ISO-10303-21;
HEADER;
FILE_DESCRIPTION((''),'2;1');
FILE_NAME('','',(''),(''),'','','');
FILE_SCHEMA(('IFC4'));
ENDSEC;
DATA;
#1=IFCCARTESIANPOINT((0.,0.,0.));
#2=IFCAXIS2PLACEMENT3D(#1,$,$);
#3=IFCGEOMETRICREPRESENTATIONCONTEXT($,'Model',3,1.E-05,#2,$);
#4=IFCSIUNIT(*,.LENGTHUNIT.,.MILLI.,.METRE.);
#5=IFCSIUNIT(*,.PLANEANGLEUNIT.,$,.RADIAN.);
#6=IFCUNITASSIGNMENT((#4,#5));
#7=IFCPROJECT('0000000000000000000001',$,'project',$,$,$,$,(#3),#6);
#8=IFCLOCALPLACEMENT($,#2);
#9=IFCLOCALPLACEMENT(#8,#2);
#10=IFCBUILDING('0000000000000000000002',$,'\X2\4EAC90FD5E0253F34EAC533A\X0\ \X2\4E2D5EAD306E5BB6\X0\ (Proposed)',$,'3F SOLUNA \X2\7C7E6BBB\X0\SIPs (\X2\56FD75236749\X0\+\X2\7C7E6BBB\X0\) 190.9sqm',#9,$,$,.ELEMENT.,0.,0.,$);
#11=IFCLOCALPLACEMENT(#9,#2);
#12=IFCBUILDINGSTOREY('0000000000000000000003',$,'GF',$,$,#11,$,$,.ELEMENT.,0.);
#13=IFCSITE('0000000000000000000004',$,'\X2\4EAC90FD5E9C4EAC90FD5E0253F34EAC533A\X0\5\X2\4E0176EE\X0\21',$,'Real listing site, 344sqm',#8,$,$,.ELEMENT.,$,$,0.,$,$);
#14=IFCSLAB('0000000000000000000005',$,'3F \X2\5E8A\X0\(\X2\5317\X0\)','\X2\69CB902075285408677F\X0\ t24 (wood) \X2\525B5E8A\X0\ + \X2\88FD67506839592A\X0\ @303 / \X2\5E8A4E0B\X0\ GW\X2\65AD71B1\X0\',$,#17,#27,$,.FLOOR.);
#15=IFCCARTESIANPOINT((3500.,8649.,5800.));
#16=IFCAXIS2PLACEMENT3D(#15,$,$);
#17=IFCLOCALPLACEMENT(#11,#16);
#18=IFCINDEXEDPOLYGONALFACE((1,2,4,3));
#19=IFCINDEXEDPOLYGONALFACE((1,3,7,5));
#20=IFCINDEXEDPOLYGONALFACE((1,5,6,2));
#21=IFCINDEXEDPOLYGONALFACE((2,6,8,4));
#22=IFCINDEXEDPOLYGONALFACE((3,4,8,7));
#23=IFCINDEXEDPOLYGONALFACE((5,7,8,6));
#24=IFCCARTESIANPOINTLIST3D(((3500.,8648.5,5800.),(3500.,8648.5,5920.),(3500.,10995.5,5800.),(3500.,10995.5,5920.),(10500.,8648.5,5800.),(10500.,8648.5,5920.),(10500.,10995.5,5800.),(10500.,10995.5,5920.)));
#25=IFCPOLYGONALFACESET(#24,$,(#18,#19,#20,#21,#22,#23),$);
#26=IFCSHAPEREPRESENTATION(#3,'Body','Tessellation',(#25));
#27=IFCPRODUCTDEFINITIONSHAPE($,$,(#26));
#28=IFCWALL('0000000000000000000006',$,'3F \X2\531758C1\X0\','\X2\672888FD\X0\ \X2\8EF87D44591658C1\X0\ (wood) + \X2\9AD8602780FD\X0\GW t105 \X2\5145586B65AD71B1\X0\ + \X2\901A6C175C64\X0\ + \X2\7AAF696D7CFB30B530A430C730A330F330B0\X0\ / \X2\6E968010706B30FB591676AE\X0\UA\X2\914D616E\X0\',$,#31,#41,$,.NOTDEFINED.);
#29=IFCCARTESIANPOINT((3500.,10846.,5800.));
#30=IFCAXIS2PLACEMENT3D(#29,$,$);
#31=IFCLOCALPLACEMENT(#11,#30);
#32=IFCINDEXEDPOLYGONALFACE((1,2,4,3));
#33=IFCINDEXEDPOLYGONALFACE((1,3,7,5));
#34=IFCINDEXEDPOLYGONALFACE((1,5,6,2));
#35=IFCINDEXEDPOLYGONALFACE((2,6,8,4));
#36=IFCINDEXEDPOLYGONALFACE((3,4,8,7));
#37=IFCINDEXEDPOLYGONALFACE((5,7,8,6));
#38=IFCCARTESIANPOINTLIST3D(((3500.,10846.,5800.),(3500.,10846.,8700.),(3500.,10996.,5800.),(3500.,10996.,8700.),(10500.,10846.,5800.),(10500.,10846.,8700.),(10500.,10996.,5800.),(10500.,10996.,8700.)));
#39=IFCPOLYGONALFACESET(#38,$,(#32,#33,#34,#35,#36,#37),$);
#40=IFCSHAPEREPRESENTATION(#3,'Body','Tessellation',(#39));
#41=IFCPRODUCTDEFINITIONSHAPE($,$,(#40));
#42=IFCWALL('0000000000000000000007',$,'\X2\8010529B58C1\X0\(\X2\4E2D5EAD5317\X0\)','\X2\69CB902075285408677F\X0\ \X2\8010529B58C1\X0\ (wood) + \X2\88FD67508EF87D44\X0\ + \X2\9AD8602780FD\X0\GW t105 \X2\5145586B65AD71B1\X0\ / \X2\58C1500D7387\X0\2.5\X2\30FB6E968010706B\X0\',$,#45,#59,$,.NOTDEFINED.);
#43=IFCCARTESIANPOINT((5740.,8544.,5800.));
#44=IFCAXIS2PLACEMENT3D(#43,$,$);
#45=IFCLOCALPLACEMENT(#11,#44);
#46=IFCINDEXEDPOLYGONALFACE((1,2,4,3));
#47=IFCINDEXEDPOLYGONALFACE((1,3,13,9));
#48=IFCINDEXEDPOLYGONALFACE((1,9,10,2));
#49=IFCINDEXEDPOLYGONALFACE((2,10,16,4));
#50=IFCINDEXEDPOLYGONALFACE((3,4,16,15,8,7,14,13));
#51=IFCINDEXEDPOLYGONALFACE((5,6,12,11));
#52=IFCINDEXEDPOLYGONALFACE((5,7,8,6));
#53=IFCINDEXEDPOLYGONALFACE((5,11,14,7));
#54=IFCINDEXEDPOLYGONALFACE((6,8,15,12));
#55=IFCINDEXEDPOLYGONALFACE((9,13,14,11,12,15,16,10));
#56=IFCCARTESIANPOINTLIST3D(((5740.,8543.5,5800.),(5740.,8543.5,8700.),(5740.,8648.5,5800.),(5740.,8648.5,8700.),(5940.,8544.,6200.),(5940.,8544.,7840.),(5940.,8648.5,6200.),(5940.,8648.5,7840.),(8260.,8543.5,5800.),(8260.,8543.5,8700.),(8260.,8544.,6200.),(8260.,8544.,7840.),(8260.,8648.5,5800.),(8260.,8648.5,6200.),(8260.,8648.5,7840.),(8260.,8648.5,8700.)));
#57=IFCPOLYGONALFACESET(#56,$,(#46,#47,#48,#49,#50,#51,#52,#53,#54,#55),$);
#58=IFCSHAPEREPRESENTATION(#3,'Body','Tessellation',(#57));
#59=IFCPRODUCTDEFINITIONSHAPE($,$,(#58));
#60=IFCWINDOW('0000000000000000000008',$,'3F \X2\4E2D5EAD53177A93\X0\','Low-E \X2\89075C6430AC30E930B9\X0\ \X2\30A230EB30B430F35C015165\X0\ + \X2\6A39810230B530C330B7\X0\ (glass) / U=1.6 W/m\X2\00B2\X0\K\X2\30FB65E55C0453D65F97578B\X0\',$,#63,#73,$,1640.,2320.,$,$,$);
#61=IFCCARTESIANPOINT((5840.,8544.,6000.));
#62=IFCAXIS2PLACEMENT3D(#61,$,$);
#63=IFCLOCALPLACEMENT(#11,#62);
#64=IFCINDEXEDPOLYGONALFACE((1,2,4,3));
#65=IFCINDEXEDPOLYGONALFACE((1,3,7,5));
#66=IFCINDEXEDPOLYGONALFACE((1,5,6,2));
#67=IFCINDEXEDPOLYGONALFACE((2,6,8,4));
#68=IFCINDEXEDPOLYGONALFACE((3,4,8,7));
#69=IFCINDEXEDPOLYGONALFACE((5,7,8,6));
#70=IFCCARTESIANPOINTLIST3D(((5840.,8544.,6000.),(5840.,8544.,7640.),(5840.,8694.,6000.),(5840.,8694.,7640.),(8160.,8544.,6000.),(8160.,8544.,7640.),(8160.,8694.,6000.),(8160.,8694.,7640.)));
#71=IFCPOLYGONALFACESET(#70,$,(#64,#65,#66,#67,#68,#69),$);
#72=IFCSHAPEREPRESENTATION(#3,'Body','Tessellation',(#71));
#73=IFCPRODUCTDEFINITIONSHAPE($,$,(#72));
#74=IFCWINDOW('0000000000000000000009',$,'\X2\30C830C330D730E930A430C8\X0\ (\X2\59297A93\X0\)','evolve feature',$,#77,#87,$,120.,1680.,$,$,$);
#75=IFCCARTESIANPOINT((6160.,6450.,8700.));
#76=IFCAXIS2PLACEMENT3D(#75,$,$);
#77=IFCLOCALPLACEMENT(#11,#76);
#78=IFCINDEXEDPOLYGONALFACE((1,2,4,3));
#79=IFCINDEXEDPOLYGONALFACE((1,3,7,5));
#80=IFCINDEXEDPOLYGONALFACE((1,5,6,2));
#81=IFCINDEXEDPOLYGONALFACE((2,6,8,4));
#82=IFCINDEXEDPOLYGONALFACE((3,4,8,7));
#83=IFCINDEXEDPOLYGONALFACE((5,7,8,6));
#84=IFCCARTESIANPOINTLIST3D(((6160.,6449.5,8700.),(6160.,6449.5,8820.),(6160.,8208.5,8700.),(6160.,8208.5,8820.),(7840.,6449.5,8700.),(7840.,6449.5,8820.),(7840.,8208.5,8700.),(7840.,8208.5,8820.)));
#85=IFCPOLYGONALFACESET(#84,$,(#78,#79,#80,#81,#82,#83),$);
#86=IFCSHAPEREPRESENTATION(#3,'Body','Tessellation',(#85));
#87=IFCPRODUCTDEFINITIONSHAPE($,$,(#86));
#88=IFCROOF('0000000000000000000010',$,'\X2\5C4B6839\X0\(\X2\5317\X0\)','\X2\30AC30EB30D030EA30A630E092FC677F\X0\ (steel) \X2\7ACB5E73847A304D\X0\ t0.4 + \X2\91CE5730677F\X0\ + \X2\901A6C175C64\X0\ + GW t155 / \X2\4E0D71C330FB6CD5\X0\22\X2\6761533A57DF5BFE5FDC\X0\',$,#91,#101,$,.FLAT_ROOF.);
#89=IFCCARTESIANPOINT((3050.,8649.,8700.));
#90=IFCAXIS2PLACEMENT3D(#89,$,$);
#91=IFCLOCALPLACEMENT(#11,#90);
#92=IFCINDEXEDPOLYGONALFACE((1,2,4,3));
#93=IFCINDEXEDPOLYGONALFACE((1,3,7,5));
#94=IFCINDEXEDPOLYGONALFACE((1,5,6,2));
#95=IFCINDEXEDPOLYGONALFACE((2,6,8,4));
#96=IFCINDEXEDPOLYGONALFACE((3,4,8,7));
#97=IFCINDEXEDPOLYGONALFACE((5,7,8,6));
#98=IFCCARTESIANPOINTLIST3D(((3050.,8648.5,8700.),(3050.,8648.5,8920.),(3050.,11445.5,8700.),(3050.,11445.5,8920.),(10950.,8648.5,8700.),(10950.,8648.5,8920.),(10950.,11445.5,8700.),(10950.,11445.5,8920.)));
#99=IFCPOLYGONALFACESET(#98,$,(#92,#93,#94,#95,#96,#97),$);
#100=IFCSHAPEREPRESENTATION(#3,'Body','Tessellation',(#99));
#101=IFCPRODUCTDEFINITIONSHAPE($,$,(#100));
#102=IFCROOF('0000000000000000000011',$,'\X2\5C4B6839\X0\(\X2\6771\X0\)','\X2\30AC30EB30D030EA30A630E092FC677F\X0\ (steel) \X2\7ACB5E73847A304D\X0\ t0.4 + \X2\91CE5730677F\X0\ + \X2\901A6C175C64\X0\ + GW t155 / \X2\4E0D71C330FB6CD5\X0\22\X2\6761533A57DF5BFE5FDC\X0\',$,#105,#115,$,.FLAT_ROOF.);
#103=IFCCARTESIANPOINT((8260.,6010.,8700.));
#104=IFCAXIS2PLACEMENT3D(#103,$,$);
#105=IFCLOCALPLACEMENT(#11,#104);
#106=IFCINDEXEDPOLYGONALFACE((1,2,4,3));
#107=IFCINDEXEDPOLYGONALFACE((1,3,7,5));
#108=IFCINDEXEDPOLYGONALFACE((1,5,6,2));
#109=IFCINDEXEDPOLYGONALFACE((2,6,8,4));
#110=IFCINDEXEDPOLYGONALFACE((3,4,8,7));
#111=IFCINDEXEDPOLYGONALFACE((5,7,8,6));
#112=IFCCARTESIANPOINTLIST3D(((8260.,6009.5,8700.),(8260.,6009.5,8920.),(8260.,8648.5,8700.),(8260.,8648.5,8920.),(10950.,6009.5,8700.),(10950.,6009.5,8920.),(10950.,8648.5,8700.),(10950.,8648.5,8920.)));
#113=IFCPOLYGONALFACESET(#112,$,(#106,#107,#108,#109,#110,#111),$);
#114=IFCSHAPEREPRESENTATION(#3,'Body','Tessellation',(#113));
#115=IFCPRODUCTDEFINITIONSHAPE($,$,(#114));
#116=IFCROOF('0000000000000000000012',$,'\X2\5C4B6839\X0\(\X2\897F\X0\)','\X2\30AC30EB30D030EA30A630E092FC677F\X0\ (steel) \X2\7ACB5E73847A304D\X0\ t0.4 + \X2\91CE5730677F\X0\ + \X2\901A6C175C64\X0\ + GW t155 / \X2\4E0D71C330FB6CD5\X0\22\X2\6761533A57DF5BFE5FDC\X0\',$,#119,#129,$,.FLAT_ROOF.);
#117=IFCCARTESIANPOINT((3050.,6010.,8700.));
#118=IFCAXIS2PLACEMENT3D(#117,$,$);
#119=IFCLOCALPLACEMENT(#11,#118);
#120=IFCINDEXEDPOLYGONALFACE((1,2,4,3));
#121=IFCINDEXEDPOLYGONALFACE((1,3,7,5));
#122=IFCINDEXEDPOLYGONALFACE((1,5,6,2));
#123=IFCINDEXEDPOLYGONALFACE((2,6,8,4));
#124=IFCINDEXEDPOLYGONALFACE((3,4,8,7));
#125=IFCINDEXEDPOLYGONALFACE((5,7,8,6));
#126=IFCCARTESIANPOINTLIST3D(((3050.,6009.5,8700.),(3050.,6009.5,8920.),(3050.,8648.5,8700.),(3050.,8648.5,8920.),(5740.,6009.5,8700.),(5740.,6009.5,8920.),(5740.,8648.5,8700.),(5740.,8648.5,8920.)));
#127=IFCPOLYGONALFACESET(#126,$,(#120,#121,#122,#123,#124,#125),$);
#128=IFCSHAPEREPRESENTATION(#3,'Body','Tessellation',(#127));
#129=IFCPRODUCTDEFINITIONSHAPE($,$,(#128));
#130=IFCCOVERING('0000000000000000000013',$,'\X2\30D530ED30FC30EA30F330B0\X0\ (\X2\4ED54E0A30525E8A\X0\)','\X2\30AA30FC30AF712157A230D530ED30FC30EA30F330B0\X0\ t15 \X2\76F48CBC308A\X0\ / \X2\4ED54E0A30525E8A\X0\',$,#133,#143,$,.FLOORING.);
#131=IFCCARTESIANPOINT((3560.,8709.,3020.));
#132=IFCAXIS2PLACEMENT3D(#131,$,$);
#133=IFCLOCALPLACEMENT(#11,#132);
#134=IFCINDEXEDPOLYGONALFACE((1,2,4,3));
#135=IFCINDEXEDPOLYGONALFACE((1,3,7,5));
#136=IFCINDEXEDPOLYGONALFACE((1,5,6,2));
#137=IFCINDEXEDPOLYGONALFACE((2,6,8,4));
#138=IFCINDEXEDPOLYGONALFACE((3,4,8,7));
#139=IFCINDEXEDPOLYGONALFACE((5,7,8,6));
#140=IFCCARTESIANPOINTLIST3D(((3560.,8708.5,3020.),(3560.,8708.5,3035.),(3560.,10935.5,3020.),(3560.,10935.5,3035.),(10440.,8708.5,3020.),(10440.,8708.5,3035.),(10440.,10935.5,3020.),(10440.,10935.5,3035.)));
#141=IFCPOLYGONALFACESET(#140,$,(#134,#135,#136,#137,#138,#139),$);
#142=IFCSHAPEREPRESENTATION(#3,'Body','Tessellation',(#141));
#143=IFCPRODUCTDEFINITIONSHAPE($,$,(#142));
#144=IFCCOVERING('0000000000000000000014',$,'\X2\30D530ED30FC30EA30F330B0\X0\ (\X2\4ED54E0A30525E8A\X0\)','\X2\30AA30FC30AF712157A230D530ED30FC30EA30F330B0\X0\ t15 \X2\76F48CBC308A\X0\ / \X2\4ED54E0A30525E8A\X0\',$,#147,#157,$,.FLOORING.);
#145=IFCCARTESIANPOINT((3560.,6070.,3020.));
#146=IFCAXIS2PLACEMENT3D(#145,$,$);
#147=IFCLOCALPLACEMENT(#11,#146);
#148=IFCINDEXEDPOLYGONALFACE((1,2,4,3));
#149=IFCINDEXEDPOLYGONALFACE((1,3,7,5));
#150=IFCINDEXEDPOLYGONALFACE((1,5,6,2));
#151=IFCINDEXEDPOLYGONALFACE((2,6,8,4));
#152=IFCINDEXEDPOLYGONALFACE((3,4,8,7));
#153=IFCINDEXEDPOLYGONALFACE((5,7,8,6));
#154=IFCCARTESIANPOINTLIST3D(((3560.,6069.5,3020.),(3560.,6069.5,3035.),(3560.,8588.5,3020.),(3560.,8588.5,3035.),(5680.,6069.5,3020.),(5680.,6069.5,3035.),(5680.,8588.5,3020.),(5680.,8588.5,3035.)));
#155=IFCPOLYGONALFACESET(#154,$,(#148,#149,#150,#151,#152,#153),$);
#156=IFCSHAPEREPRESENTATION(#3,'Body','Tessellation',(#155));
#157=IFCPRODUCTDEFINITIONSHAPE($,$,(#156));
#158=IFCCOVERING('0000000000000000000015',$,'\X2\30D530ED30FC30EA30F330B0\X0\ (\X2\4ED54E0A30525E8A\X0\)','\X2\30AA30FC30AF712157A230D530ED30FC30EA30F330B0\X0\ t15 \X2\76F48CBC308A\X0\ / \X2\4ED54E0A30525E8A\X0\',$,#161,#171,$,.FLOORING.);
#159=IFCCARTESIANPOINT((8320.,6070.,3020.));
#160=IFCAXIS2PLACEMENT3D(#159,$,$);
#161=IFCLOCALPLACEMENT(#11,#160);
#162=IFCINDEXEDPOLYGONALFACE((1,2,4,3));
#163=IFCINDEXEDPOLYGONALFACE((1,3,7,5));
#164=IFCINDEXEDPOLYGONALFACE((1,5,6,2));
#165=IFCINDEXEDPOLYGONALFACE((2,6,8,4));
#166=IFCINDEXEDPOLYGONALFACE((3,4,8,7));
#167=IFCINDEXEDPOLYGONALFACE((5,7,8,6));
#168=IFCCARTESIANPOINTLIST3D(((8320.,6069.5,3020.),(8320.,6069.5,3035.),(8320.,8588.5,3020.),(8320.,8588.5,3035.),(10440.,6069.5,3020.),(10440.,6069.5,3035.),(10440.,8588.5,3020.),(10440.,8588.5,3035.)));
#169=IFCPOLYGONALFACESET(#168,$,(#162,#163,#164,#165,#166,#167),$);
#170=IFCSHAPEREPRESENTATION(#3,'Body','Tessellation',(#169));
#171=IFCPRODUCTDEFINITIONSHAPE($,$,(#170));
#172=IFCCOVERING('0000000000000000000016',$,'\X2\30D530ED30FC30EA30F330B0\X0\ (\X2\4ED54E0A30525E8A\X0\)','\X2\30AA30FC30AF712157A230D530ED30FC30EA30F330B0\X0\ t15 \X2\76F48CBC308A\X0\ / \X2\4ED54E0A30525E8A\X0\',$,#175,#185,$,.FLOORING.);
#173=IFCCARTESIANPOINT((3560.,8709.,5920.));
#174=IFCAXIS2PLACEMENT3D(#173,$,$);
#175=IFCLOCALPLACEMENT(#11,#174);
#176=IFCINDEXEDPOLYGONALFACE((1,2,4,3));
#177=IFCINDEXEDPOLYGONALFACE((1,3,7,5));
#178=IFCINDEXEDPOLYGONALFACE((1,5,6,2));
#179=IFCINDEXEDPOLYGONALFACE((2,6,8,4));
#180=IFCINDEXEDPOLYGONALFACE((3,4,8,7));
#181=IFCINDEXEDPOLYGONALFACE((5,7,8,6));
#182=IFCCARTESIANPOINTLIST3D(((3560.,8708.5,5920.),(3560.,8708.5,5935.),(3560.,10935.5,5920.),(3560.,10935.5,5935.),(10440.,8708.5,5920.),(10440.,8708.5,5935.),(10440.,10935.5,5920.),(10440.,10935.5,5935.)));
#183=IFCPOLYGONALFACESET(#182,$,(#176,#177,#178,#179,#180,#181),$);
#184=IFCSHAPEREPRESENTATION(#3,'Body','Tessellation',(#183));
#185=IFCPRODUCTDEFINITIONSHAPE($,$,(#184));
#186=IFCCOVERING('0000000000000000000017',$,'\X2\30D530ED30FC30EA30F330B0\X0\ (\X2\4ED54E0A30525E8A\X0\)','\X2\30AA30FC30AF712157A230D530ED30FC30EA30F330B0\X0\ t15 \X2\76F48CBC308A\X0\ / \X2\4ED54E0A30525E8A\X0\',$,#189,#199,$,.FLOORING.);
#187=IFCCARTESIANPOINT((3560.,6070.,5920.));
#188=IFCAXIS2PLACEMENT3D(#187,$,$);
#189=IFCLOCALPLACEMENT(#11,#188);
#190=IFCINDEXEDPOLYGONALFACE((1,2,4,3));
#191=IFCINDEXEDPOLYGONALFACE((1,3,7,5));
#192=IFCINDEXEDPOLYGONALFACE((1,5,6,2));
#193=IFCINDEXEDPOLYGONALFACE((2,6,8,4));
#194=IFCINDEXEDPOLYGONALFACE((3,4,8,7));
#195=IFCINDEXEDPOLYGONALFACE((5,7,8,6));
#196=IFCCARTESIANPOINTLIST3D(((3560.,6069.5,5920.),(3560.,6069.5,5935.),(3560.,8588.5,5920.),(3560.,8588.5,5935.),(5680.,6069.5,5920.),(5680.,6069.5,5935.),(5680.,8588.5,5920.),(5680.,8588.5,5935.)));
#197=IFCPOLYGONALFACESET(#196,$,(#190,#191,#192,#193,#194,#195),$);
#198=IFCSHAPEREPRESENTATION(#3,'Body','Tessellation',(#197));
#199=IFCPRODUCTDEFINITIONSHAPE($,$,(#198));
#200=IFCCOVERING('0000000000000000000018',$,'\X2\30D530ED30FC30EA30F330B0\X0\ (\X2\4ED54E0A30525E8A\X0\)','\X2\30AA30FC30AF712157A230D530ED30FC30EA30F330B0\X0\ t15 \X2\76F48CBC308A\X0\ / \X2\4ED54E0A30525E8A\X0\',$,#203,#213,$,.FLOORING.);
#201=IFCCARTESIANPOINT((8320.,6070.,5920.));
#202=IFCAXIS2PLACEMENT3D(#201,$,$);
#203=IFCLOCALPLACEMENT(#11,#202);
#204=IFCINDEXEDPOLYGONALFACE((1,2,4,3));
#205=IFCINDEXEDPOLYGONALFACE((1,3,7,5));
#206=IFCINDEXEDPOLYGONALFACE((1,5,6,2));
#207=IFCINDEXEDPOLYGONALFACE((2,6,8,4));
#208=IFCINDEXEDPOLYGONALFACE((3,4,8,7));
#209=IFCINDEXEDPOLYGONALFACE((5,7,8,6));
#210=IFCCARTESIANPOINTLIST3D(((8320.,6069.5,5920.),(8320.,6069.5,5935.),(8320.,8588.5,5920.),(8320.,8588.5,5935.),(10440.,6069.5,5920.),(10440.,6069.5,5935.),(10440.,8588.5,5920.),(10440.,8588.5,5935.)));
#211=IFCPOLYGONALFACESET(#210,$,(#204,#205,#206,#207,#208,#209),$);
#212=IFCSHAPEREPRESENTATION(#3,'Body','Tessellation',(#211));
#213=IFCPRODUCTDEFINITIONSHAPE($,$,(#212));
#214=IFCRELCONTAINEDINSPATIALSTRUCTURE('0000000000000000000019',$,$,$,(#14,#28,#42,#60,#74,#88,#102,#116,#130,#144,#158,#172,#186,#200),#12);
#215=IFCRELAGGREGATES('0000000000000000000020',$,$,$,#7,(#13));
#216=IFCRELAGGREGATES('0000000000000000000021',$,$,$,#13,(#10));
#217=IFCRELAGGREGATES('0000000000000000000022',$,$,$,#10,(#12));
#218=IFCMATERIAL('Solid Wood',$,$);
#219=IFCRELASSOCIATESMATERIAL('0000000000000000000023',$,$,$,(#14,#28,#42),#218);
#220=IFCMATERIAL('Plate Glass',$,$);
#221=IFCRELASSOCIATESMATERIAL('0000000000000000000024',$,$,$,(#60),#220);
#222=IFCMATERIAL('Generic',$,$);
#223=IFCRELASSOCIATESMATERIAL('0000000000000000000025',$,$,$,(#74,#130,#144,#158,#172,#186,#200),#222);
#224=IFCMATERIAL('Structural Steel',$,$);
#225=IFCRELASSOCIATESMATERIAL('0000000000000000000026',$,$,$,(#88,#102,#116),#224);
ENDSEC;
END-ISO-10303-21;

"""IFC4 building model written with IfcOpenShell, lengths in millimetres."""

from ifc_helpers import new_model, si_unit, frame, frame_2d, origin, place, context, project, spatial, rectangle, extrude, material, element, fill, save


model = new_model("IFC4")

# Units and contexts
model_context = context("Model", 3, precision=1e-05, world=origin())
ifc_project = project(units=[si_unit("LENGTHUNIT", "METRE", prefix="MILLI"), si_unit("PLANEANGLEUNIT", "RADIAN")], contexts=[model_context])

# Site, building, storey
site_placement = place(None, origin())
site = spatial("IfcSite", under=ifc_project, at=site_placement, Name="京都府京都市右京区5丁目21", ObjectType="Real listing site, 344sqm", CompositionType="ELEMENT", RefElevation=0.0)
building_placement = place(site_placement, origin())
building = spatial("IfcBuilding", under=site, at=building_placement, Name="京都市右京区 中庭の家 (Proposed)", ObjectType="3F SOLUNA 籾殻SIPs (国産杉+籾殻) 190.9sqm", CompositionType="ELEMENT", ElevationOfRefHeight=0.0, ElevationOfTerrain=0.0)
storey_placement = place(building_placement, origin())
storey = spatial("IfcBuildingStorey", under=building, at=storey_placement, Name="GF", CompositionType="ELEMENT", Elevation=0.0)

# Slab
ifc_material_1 = material(Name="Solid Wood")
slab_placement = place(storey_placement, frame((3500.0, 8649.0, 5800.0)))
element("IfcSlab", 1, at=slab_placement, inside=storey, material=ifc_material_1, Name="3F 床(北)", Description="構造用合板 t24 (wood) 剛床 + 製材根太 @303 / 床下 GW断熱", PredefinedType="FLOOR", context=model_context, shape_type="SweptSolid", body=[
    extrude(rectangle(XDim=7000.0, YDim=2347.0, at=frame_2d((3500.0, 1173.0))), frame((3500.0, 8649.0, 5800.0)), (0.0, 0.0, 1.0), 120.0),
])

# Wall
wall_1_placement = place(storey_placement, frame((3500.0, 10846.0, 5800.0)))
element("IfcWall", 2, at=wall_1_placement, inside=storey, material=ifc_material_1, Name="3F 北壁", Description="木製 軸組外壁 (wood) + 高性能GW t105 充填断熱 + 通気層 + 窯業系サイディング / 準耐火・外皮UA配慮", PredefinedType="NOTDEFINED", context=model_context, shape_type="SweptSolid", body=[
    extrude(rectangle(XDim=7000.0, YDim=150.0, at=frame_2d((3500.0, 75.0))), frame((3500.0, 10846.0, 5800.0)), (0.0, 0.0, 1.0), 2900.0),
])

# Wall, opening, window
wall_2_placement = place(storey_placement, frame((5740.0, 8544.0, 5800.0)))
wall_2 = element("IfcWall", 3, at=wall_2_placement, inside=storey, material=ifc_material_1, Name="耐力壁(中庭北)", Description="構造用合板 耐力壁 (wood) + 製材軸組 + 高性能GW t105 充填断熱 / 壁倍率2.5・準耐火", PredefinedType="NOTDEFINED", context=model_context, shape_type="SweptSolid", body=[
    extrude(rectangle(XDim=2520.0, YDim=105.0, at=frame_2d((1260.0, 52.0))), frame((5740.0, 8544.0, 5800.0)), (0.0, 0.0, 1.0), 2900.0),
])
opening_placement = place(storey_placement, frame((5840.0, 8544.0, 6000.0)))
opening = element("IfcOpeningElement", 4, at=opening_placement, cuts=wall_2, PredefinedType="NOTDEFINED", context=model_context, shape_type="SweptSolid", body=[
    extrude(rectangle(XDim=2320.0, YDim=150.0, at=frame_2d((1160.0, 75.0))), frame((5840.0, 8544.0, 6000.0)), (0.0, 0.0, 1.0), 1640.0),
])
ifc_material_2 = material(Name="Plate Glass")
window_1_placement = place(storey_placement, frame((5840.0, 8544.0, 6000.0)))
window_1 = element("IfcWindow", 5, at=window_1_placement, inside=storey, material=ifc_material_2, Name="3F 中庭北窓", Description="Low-E 複層ガラス アルゴン封入 + 樹脂サッシ (glass) / U=1.6 W/m²K・日射取得型", OverallHeight=1640.0, OverallWidth=2320.0, context=model_context, shape_type="SweptSolid", body=[
    extrude(rectangle(XDim=2320.0, YDim=150.0, at=frame_2d((1160.0, 75.0))), frame((5840.0, 8544.0, 6000.0)), (0.0, 0.0, 1.0), 1640.0),
])
fill(opening, window_1)

# Window
ifc_material_3 = material(Name="Generic")
window_2_placement = place(storey_placement, frame((6160.0, 6450.0, 8700.0)))
element("IfcWindow", 6, at=window_2_placement, inside=storey, material=ifc_material_3, Name="トップライト (天窓)", Description="evolve feature", OverallHeight=120.0, OverallWidth=1680.0, context=model_context, shape_type="SweptSolid", body=[
    extrude(rectangle(XDim=1680.0, YDim=1759.0, at=frame_2d((840.0, 879.0))), frame((6160.0, 6450.0, 8700.0)), (0.0, 0.0, 1.0), 120.0),
])

# Roofs
ifc_material_4 = material(Name="Structural Steel")
roof_1_placement = place(storey_placement, frame((3050.0, 8649.0, 8700.0)))
element("IfcRoof", 7, at=roof_1_placement, inside=storey, material=ifc_material_4, Name="屋根(北)", Description="ガルバリウム鋼板 (steel) 立平葺き t0.4 + 野地板 + 通気層 + GW t155 / 不燃・法22条区域対応", PredefinedType="FLAT_ROOF", context=model_context, shape_type="SweptSolid", body=[
    extrude(rectangle(XDim=7900.0, YDim=2797.0, at=frame_2d((3950.0, 1398.0))), frame((3050.0, 8649.0, 8700.0)), (0.0, 0.0, 1.0), 220.0),
])
roof_2_placement = place(storey_placement, frame((8260.0, 6010.0, 8700.0)))
element("IfcRoof", 8, at=roof_2_placement, inside=storey, material=ifc_material_4, Name="屋根(東)", Description="ガルバリウム鋼板 (steel) 立平葺き t0.4 + 野地板 + 通気層 + GW t155 / 不燃・法22条区域対応", PredefinedType="FLAT_ROOF", context=model_context, shape_type="SweptSolid", body=[
    extrude(rectangle(XDim=2690.0, YDim=2639.0, at=frame_2d((1345.0, 1319.0))), frame((8260.0, 6010.0, 8700.0)), (0.0, 0.0, 1.0), 220.0),
])
roof_3_placement = place(storey_placement, frame((3050.0, 6010.0, 8700.0)))
element("IfcRoof", 9, at=roof_3_placement, inside=storey, material=ifc_material_4, Name="屋根(西)", Description="ガルバリウム鋼板 (steel) 立平葺き t0.4 + 野地板 + 通気層 + GW t155 / 不燃・法22条区域対応", PredefinedType="FLAT_ROOF", context=model_context, shape_type="SweptSolid", body=[
    extrude(rectangle(XDim=2690.0, YDim=2639.0, at=frame_2d((1345.0, 1319.0))), frame((3050.0, 6010.0, 8700.0)), (0.0, 0.0, 1.0), 220.0),
])

# Coverings
covering_1_placement = place(storey_placement, frame((3560.0, 8709.0, 3020.0)))
element("IfcCovering", 10, at=covering_1_placement, inside=storey, material=ifc_material_3, Name="フローリング (仕上げ床)", Description="オーク無垢フローリング t15 直貼り / 仕上げ床", PredefinedType="FLOORING", context=model_context, shape_type="SweptSolid", body=[
    extrude(rectangle(XDim=6880.0, YDim=2227.0, at=frame_2d((3440.0, 1113.0))), frame((3560.0, 8709.0, 3020.0)), (0.0, 0.0, 1.0), 15.0),
])
covering_2_placement = place(storey_placement, frame((3560.0, 6070.0, 3020.0)))
element("IfcCovering", 11, at=covering_2_placement, inside=storey, material=ifc_material_3, Name="フローリング (仕上げ床)", Description="オーク無垢フローリング t15 直貼り / 仕上げ床", PredefinedType="FLOORING", context=model_context, shape_type="SweptSolid", body=[
    extrude(rectangle(XDim=2120.0, YDim=2519.0, at=frame_2d((1060.0, 1259.0))), frame((3560.0, 6070.0, 3020.0)), (0.0, 0.0, 1.0), 15.0),
])
covering_3_placement = place(storey_placement, frame((8320.0, 6070.0, 3020.0)))
element("IfcCovering", 12, at=covering_3_placement, inside=storey, material=ifc_material_3, Name="フローリング (仕上げ床)", Description="オーク無垢フローリング t15 直貼り / 仕上げ床", PredefinedType="FLOORING", context=model_context, shape_type="SweptSolid", body=[
    extrude(rectangle(XDim=2120.0, YDim=2519.0, at=frame_2d((1060.0, 1259.0))), frame((8320.0, 6070.0, 3020.0)), (0.0, 0.0, 1.0), 15.0),
])
covering_4_placement = place(storey_placement, frame((3560.0, 8709.0, 5920.0)))
element("IfcCovering", 13, at=covering_4_placement, inside=storey, material=ifc_material_3, Name="フローリング (仕上げ床)", Description="オーク無垢フローリング t15 直貼り / 仕上げ床", PredefinedType="FLOORING", context=model_context, shape_type="SweptSolid", body=[
    extrude(rectangle(XDim=6880.0, YDim=2227.0, at=frame_2d((3440.0, 1113.0))), frame((3560.0, 8709.0, 5920.0)), (0.0, 0.0, 1.0), 15.0),
])
covering_5_placement = place(storey_placement, frame((3560.0, 6070.0, 5920.0)))
element("IfcCovering", 14, at=covering_5_placement, inside=storey, material=ifc_material_3, Name="フローリング (仕上げ床)", Description="オーク無垢フローリング t15 直貼り / 仕上げ床", PredefinedType="FLOORING", context=model_context, shape_type="SweptSolid", body=[
    extrude(rectangle(XDim=2120.0, YDim=2519.0, at=frame_2d((1060.0, 1259.0))), frame((3560.0, 6070.0, 5920.0)), (0.0, 0.0, 1.0), 15.0),
])
covering_6_placement = place(storey_placement, frame((8320.0, 6070.0, 5920.0)))
element("IfcCovering", 15, at=covering_6_placement, inside=storey, material=ifc_material_3, Name="フローリング (仕上げ床)", Description="オーク無垢フローリング t15 直貼り / 仕上げ床", PredefinedType="FLOORING", context=model_context, shape_type="SweptSolid", body=[
    extrude(rectangle(XDim=2120.0, YDim=2519.0, at=frame_2d((1060.0, 1259.0))), frame((8320.0, 6070.0, 5920.0)), (0.0, 0.0, 1.0), 15.0),
])

save(model, "model.ifc")
